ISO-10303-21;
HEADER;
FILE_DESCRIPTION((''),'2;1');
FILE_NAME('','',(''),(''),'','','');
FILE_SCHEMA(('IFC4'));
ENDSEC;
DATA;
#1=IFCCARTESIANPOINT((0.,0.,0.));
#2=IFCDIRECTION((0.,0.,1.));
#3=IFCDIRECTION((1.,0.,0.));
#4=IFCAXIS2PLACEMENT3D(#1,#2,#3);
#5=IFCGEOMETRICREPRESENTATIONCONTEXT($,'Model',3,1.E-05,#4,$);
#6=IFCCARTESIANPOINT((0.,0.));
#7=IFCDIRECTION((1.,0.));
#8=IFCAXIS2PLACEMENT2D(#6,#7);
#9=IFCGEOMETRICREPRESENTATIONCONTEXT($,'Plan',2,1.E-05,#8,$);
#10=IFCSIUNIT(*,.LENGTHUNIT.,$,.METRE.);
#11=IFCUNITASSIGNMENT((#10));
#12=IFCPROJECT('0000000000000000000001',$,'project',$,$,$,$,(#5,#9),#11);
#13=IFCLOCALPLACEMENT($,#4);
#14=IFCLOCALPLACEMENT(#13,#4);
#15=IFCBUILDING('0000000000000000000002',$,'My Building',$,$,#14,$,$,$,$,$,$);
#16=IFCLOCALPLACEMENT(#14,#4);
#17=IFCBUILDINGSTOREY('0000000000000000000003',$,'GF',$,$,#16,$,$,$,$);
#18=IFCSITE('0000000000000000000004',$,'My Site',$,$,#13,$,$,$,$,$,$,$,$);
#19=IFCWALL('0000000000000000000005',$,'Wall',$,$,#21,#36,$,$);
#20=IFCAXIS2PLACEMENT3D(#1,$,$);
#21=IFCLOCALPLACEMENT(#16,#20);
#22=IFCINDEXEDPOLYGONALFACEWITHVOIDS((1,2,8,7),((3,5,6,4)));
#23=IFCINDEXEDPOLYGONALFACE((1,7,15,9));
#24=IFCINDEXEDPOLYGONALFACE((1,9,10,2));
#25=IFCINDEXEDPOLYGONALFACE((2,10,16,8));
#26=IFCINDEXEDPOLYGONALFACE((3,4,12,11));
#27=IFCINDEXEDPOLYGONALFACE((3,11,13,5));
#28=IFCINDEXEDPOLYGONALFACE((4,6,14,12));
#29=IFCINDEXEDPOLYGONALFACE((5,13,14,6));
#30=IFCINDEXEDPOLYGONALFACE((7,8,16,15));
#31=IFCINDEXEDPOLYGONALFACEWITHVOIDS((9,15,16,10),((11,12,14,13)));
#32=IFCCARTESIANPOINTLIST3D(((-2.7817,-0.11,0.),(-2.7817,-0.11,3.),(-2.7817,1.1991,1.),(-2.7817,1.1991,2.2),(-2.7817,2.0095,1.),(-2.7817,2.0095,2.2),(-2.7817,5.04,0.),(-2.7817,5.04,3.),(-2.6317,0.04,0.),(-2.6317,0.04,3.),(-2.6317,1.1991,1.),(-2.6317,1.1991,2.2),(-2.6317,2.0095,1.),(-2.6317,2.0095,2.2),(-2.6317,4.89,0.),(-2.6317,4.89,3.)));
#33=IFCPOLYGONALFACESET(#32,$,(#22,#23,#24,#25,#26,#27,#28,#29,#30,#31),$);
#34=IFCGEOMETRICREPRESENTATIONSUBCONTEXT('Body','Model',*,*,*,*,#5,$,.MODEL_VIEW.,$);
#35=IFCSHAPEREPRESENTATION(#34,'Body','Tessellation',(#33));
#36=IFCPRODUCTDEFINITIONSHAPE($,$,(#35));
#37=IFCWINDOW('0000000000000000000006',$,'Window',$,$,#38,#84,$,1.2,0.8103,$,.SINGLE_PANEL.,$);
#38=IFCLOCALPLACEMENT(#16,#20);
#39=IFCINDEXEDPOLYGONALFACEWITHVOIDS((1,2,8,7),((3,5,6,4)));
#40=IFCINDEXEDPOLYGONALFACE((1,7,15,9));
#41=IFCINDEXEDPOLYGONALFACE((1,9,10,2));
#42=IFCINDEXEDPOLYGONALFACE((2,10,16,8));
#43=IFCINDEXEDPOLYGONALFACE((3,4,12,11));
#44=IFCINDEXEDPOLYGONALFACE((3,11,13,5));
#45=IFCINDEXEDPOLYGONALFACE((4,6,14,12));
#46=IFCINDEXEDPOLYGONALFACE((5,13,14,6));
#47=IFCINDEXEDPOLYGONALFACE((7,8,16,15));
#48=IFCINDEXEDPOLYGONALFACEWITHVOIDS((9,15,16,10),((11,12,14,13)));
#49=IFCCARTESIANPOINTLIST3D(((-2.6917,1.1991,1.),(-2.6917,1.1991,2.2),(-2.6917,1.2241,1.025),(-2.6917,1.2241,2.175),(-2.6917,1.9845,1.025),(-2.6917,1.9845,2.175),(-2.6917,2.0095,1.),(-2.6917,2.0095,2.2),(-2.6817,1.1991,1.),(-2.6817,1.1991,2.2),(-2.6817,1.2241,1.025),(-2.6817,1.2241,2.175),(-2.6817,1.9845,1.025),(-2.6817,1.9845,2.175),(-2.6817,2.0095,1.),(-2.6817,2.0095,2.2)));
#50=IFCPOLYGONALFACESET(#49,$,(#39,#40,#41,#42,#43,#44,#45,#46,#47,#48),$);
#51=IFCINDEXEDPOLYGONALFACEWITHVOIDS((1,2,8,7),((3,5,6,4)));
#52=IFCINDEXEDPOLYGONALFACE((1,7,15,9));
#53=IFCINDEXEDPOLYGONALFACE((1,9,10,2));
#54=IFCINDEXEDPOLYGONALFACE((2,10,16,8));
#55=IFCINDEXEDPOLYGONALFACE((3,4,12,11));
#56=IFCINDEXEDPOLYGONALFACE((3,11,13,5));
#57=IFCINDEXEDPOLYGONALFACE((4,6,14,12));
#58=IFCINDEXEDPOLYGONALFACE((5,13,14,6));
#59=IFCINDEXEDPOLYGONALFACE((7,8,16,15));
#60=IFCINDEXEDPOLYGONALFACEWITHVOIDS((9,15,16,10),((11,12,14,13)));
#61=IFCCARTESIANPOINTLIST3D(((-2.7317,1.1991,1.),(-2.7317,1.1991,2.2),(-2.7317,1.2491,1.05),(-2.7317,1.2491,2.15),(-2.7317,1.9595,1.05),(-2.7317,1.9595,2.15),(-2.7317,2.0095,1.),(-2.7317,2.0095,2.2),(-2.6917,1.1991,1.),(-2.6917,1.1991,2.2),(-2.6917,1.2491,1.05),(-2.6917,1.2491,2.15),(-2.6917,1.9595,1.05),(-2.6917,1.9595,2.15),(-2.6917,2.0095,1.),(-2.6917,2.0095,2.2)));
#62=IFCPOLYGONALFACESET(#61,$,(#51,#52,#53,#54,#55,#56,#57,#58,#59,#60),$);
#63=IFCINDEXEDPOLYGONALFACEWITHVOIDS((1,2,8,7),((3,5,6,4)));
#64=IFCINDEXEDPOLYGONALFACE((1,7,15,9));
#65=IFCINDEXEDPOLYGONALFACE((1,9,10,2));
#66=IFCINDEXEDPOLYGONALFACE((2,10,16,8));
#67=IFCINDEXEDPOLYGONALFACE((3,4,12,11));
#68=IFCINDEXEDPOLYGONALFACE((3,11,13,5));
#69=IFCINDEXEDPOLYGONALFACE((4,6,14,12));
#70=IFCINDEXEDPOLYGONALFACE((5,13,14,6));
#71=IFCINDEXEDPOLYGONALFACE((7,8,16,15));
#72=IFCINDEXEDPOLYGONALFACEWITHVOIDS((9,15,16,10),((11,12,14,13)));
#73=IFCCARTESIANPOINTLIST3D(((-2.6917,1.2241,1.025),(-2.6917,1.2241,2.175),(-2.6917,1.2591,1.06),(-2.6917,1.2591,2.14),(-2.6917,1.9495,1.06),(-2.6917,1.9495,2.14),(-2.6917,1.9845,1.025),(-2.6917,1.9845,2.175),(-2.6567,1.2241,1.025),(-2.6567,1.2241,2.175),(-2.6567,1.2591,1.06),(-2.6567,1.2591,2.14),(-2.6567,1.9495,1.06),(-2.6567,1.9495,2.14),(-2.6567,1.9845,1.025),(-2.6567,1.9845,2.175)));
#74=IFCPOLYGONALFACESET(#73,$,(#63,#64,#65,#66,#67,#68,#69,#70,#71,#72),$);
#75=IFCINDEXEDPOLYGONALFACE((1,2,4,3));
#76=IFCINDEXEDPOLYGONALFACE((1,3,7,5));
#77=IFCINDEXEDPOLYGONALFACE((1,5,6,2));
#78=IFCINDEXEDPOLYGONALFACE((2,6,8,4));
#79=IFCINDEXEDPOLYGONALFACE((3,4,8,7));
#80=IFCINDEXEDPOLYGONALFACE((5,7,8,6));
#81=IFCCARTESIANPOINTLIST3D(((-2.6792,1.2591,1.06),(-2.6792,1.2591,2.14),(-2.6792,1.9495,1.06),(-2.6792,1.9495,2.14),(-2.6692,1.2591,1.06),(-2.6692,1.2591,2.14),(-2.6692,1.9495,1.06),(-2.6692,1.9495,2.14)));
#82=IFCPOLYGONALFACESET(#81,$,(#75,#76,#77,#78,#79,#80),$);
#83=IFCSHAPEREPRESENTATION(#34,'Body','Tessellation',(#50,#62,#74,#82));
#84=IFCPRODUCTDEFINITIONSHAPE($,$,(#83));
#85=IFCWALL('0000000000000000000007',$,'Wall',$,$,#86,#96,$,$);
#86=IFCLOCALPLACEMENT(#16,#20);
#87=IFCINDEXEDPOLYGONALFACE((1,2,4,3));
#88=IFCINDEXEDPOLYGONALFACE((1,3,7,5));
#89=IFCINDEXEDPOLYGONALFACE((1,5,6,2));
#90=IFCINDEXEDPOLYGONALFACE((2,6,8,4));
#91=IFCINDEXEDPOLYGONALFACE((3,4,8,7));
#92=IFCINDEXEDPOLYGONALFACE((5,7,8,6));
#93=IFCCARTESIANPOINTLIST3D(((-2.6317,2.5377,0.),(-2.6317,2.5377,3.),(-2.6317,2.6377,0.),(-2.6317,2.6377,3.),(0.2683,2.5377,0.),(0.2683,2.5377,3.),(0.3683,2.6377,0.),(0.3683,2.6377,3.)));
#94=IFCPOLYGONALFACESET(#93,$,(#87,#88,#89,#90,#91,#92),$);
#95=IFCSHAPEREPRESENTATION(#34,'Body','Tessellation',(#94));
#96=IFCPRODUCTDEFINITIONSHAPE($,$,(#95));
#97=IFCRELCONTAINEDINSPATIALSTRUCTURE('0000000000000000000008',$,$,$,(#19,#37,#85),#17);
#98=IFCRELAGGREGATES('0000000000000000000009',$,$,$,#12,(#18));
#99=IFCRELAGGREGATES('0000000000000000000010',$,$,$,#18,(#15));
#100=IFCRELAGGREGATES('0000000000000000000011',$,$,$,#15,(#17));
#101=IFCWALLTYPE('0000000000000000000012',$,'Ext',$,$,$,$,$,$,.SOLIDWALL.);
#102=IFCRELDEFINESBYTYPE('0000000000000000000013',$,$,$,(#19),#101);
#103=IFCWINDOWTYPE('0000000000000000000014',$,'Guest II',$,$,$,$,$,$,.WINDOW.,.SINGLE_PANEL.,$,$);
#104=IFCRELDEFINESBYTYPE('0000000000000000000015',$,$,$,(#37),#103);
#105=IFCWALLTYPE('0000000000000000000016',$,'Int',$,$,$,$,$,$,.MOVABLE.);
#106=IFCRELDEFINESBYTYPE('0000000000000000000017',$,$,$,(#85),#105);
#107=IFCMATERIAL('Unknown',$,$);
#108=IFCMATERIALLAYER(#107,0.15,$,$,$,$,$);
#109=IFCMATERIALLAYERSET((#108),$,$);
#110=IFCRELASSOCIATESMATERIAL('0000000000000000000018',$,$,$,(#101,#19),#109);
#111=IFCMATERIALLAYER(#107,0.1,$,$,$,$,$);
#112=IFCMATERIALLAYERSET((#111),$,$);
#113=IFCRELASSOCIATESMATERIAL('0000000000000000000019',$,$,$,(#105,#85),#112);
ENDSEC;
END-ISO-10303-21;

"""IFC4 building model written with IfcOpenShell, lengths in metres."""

from ifc_helpers import new_model, entity, si_unit, frame, origin_with_axes, origin_2d_with_axis, place, context, subcontext, project, spatial, line, indexed_curve, outline, extrude, shape, source, transform, mapped, material, layer, layer_set, layer_usage, type_object, type_shapes, element, fill, save


model = new_model("IFC4")

# Units and contexts
model_context = context("Model", 3, precision=1e-05, world=origin_with_axes())
plan_context = context("Plan", 2, precision=1e-05, world=origin_2d_with_axis())
body_context_1 = subcontext(model_context, "Body", "Model", "MODEL_VIEW")
body_context_2 = subcontext(plan_context, "Body", "Plan", "PLAN_VIEW")
ifc_project = project(units=[si_unit("LENGTHUNIT", "METRE")], contexts=[model_context, plan_context])

# Site, building, storey
site_placement = place(None, origin_with_axes())
site = spatial("IfcSite", under=ifc_project, at=site_placement, Name="My Site")
building_placement = place(site_placement, origin_with_axes())
building = spatial("IfcBuilding", under=site, at=building_placement, Name="My Building")
storey_placement = place(building_placement, origin_with_axes())
storey = spatial("IfcBuildingStorey", under=building, at=storey_placement, Name="GF")

# Shared definitions
ifc_material = material(Name="Unknown")

# Shared definitions
ifc_layer_1 = layer(ifc_material, 0.15)
ifc_layer_set_1 = layer_set([ifc_layer_1])
wall_type_1 = type_object("IfcWallType", Name="Ext", PredefinedType="SOLIDWALL", material=ifc_layer_set_1)

# Wall, opening, window
ifc_layer_usage_1 = layer_usage(ifc_layer_set_1, "AXIS2", "POSITIVE", 0.0)
wall_1_placement = place(storey_placement, frame((-2.7817, 5.04, 0.0), z_axis=(0.0, 0.0, 1.0), x_axis=(0.0, -1.0, 0.0)))
wall_1 = element("IfcWall", 1, at=wall_1_placement, inside=storey, type_object=wall_type_1, material=ifc_layer_usage_1, Name="Wall", context=body_context_1, shape_type="SweptSolid", body=[
    extrude(outline(indexed_curve([(0.0, 0.0), (0.15, 0.15), (5.0, 0.15), (5.15, 0.0)], segments=[line(1, 2, 3, 4, 1)])), origin_with_axes(), (0.0, 0.0, 1.0), 3.0),
])
shared_shape_1 = source(origin_with_axes(), body_context_1, "Body", "SweptSolid", [
    extrude(outline(indexed_curve([(0.0, 0.0), (0.8103, 0.0), (0.8103, 1.2), (0.0, 1.2)], segments=[line(1, 2, 3, 4, 1)])), frame((0.0, -0.6, 0.0), z_axis=(0.0, -1.0, 0.0), x_axis=(1.0, 0.0, 0.0)), (0.0, 0.0, -1.0), 1.2),
])
opening_1_placement = place(wall_1_placement, frame((3.0305, 0.0, 1.0), z_axis=(0.0, 0.0, 1.0), x_axis=(1.0, 0.0, 0.0)))
opening_1 = element("IfcOpeningElement", 2, at=opening_1_placement, cuts=wall_1, PredefinedType="OPENING", context=body_context_1, shape_type="MappedRepresentation", body=[
    mapped(shared_shape_1, transform((0.0, 0.0, 0.0), x_axis=(1.0, 0.0, 0.0), y_axis=(0.0, 1.0, 0.0), z_axis=(0.0, 0.0, 1.0), scale=1.0)),
])
window_type_1 = type_object("IfcWindowType", Name="Guest II", PartitioningType="SINGLE_PANEL", PredefinedType="WINDOW")
shared_shape_2 = source(origin_with_axes(), body_context_1, "Body", "SweptSolid", [
    extrude(outline(indexed_curve([(0.0, 0.0), (0.8103, 0.0), (0.8103, 1.2), (0.0, 1.2)], segments=[line(1, 2, 3, 4, 1)]), holes=[indexed_curve([(0.025, 0.025), (0.7853, 0.025), (0.7853, 1.175), (0.025, 1.175)], segments=[line(1, 2, 3, 4, 1)])]), frame((0.0, 0.09, 0.0), z_axis=(0.0, -1.0, 0.0), x_axis=(1.0, 0.0, 0.0)), (0.0, 0.0, -1.0), 0.01),
    extrude(outline(indexed_curve([(0.0, 0.0), (0.8103, 0.0), (0.8103, 1.2), (0.0, 1.2)], segments=[line(1, 2, 3, 4, 1)]), holes=[indexed_curve([(0.05, 0.05), (0.7603, 0.05), (0.7603, 1.15), (0.05, 1.15)], segments=[line(1, 2, 3, 4, 1)])]), frame((0.0, 0.05, 0.0), z_axis=(0.0, -1.0, 0.0), x_axis=(1.0, 0.0, 0.0)), (0.0, 0.0, -1.0), 0.04),
    extrude(outline(indexed_curve([(0.0, 1.15), (0.7603, 1.15), (0.7603, 0.0), (0.0, 0.0), (0.0, 1.15)]), holes=[indexed_curve([(0.035, 1.115), (0.7253, 1.115), (0.7253, 0.035), (0.035, 0.035), (0.035, 1.115)])]), frame((0.025, 0.09, 0.025), z_axis=(0.0, -1.0, 0.0), x_axis=(1.0, 0.0, 0.0)), (0.0, 0.0, -1.0), 0.035),
    extrude(outline(indexed_curve([(0.035, 0.035), (0.7253, 0.035), (0.7253, 1.115), (0.035, 1.115)], segments=[line(1, 2, 3, 4, 1)])), frame((0.025, 0.1025, 0.025), z_axis=(0.0, -1.0, 0.0), x_axis=(1.0, 0.0, 0.0)), (0.0, 0.0, -1.0), 0.01),
])
shared_shape_3 = source(origin_with_axes(), body_context_2, "Body", "Curve2D", [
    entity("IfcIndexedPolyCurve", entity("IfcCartesianPointList2D", [[0.05, 0.05], [0.7603, 0.05]])),
    entity("IfcIndexedPolyCurve", entity("IfcCartesianPointList2D", [[0.0, 0.1], [0.025, 0.1], [0.025, 0.09], [0.05, 0.09], [0.05, 0.05], [0.0, 0.05]]), [entity("IfcLineIndex", [1, 2, 3, 4, 5, 6, 1])]),
    entity("IfcIndexedPolyCurve", entity("IfcCartesianPointList2D", [[0.8103, 0.1], [0.7853, 0.1], [0.7853, 0.09], [0.7603, 0.09], [0.7603, 0.05], [0.8103, 0.05]]), [entity("IfcLineIndex", [1, 2, 3, 4, 5, 6, 1])]),
    entity("IfcIndexedPolyCurve", entity("IfcCartesianPointList2D", [[0.025, 0.09], [0.06, 0.09], [0.06, 0.125], [0.025, 0.125]]), [entity("IfcLineIndex", [1, 2, 3, 4, 1])]),
    entity("IfcIndexedPolyCurve", entity("IfcCartesianPointList2D", [[0.7853, 0.09], [0.7503, 0.09], [0.7503, 0.125], [0.7853, 0.125]]), [entity("IfcLineIndex", [1, 2, 3, 4, 1])]),
    entity("IfcIndexedPolyCurve", entity("IfcCartesianPointList2D", [[0.06, 0.09], [0.7503, 0.09]])),
    entity("IfcIndexedPolyCurve", entity("IfcCartesianPointList2D", [[0.06, 0.125], [0.7503, 0.125]])),
    entity("IfcIndexedPolyCurve", entity("IfcCartesianPointList2D", [[0.06, 0.1075], [0.7503, 0.1075]])),
])
type_shapes(window_type_1, [shared_shape_2, shared_shape_3])
window_1_placement = place(opening_1_placement, frame((0.0, 0.0, 0.0), z_axis=(0.0, 0.0, 1.0), x_axis=(1.0, 0.0, 0.0)))
window_1 = element("IfcWindow", 3, at=window_1_placement, inside=storey, type_object=window_type_1, Name="Window", OverallHeight=1.2, OverallWidth=0.8103, PartitioningType="SINGLE_PANEL", shapes=[
    shape(body_context_1, "Body", "MappedRepresentation", [mapped(shared_shape_2, transform((0.0, 0.0, 0.0), x_axis=(1.0, 0.0, 0.0), y_axis=(0.0, 1.0, 0.0), z_axis=(0.0, 0.0, 1.0), scale=1.0))]),
    shape(body_context_2, "Body", "MappedRepresentation", [mapped(shared_shape_3, transform((0.0, 0.0, 0.0), x_axis=(1.0, 0.0, 0.0), y_axis=(0.0, 1.0, 0.0), z_axis=(0.0, 0.0, 1.0), scale=1.0))]),
])
fill(opening_1, window_1)

# Wall
ifc_layer_2 = layer(ifc_material, 0.1)
ifc_layer_set_2 = layer_set([ifc_layer_2])
ifc_layer_usage_2 = layer_usage(ifc_layer_set_2, "AXIS2", "POSITIVE", 0.0)
wall_type_2 = type_object("IfcWallType", Name="Int", PredefinedType="MOVABLE", material=ifc_layer_set_2)
wall_2_placement = place(storey_placement, frame((-2.6317, 2.5377, 0.0), z_axis=(0.0, 0.0, 1.0), x_axis=(1.0, 0.0, 0.0)))
element("IfcWall", 4, at=wall_2_placement, inside=storey, type_object=wall_type_2, material=ifc_layer_usage_2, Name="Wall", context=body_context_1, shape_type="SweptSolid", body=[
    extrude(outline(indexed_curve([(0.0, 0.0), (0.0, 0.1), (3.0, 0.1), (2.9, 0.0)], segments=[line(1, 2, 3, 4, 1)])), origin_with_axes(), (0.0, 0.0, 1.0), 3.0),
])

save(model, "model.ifc")
